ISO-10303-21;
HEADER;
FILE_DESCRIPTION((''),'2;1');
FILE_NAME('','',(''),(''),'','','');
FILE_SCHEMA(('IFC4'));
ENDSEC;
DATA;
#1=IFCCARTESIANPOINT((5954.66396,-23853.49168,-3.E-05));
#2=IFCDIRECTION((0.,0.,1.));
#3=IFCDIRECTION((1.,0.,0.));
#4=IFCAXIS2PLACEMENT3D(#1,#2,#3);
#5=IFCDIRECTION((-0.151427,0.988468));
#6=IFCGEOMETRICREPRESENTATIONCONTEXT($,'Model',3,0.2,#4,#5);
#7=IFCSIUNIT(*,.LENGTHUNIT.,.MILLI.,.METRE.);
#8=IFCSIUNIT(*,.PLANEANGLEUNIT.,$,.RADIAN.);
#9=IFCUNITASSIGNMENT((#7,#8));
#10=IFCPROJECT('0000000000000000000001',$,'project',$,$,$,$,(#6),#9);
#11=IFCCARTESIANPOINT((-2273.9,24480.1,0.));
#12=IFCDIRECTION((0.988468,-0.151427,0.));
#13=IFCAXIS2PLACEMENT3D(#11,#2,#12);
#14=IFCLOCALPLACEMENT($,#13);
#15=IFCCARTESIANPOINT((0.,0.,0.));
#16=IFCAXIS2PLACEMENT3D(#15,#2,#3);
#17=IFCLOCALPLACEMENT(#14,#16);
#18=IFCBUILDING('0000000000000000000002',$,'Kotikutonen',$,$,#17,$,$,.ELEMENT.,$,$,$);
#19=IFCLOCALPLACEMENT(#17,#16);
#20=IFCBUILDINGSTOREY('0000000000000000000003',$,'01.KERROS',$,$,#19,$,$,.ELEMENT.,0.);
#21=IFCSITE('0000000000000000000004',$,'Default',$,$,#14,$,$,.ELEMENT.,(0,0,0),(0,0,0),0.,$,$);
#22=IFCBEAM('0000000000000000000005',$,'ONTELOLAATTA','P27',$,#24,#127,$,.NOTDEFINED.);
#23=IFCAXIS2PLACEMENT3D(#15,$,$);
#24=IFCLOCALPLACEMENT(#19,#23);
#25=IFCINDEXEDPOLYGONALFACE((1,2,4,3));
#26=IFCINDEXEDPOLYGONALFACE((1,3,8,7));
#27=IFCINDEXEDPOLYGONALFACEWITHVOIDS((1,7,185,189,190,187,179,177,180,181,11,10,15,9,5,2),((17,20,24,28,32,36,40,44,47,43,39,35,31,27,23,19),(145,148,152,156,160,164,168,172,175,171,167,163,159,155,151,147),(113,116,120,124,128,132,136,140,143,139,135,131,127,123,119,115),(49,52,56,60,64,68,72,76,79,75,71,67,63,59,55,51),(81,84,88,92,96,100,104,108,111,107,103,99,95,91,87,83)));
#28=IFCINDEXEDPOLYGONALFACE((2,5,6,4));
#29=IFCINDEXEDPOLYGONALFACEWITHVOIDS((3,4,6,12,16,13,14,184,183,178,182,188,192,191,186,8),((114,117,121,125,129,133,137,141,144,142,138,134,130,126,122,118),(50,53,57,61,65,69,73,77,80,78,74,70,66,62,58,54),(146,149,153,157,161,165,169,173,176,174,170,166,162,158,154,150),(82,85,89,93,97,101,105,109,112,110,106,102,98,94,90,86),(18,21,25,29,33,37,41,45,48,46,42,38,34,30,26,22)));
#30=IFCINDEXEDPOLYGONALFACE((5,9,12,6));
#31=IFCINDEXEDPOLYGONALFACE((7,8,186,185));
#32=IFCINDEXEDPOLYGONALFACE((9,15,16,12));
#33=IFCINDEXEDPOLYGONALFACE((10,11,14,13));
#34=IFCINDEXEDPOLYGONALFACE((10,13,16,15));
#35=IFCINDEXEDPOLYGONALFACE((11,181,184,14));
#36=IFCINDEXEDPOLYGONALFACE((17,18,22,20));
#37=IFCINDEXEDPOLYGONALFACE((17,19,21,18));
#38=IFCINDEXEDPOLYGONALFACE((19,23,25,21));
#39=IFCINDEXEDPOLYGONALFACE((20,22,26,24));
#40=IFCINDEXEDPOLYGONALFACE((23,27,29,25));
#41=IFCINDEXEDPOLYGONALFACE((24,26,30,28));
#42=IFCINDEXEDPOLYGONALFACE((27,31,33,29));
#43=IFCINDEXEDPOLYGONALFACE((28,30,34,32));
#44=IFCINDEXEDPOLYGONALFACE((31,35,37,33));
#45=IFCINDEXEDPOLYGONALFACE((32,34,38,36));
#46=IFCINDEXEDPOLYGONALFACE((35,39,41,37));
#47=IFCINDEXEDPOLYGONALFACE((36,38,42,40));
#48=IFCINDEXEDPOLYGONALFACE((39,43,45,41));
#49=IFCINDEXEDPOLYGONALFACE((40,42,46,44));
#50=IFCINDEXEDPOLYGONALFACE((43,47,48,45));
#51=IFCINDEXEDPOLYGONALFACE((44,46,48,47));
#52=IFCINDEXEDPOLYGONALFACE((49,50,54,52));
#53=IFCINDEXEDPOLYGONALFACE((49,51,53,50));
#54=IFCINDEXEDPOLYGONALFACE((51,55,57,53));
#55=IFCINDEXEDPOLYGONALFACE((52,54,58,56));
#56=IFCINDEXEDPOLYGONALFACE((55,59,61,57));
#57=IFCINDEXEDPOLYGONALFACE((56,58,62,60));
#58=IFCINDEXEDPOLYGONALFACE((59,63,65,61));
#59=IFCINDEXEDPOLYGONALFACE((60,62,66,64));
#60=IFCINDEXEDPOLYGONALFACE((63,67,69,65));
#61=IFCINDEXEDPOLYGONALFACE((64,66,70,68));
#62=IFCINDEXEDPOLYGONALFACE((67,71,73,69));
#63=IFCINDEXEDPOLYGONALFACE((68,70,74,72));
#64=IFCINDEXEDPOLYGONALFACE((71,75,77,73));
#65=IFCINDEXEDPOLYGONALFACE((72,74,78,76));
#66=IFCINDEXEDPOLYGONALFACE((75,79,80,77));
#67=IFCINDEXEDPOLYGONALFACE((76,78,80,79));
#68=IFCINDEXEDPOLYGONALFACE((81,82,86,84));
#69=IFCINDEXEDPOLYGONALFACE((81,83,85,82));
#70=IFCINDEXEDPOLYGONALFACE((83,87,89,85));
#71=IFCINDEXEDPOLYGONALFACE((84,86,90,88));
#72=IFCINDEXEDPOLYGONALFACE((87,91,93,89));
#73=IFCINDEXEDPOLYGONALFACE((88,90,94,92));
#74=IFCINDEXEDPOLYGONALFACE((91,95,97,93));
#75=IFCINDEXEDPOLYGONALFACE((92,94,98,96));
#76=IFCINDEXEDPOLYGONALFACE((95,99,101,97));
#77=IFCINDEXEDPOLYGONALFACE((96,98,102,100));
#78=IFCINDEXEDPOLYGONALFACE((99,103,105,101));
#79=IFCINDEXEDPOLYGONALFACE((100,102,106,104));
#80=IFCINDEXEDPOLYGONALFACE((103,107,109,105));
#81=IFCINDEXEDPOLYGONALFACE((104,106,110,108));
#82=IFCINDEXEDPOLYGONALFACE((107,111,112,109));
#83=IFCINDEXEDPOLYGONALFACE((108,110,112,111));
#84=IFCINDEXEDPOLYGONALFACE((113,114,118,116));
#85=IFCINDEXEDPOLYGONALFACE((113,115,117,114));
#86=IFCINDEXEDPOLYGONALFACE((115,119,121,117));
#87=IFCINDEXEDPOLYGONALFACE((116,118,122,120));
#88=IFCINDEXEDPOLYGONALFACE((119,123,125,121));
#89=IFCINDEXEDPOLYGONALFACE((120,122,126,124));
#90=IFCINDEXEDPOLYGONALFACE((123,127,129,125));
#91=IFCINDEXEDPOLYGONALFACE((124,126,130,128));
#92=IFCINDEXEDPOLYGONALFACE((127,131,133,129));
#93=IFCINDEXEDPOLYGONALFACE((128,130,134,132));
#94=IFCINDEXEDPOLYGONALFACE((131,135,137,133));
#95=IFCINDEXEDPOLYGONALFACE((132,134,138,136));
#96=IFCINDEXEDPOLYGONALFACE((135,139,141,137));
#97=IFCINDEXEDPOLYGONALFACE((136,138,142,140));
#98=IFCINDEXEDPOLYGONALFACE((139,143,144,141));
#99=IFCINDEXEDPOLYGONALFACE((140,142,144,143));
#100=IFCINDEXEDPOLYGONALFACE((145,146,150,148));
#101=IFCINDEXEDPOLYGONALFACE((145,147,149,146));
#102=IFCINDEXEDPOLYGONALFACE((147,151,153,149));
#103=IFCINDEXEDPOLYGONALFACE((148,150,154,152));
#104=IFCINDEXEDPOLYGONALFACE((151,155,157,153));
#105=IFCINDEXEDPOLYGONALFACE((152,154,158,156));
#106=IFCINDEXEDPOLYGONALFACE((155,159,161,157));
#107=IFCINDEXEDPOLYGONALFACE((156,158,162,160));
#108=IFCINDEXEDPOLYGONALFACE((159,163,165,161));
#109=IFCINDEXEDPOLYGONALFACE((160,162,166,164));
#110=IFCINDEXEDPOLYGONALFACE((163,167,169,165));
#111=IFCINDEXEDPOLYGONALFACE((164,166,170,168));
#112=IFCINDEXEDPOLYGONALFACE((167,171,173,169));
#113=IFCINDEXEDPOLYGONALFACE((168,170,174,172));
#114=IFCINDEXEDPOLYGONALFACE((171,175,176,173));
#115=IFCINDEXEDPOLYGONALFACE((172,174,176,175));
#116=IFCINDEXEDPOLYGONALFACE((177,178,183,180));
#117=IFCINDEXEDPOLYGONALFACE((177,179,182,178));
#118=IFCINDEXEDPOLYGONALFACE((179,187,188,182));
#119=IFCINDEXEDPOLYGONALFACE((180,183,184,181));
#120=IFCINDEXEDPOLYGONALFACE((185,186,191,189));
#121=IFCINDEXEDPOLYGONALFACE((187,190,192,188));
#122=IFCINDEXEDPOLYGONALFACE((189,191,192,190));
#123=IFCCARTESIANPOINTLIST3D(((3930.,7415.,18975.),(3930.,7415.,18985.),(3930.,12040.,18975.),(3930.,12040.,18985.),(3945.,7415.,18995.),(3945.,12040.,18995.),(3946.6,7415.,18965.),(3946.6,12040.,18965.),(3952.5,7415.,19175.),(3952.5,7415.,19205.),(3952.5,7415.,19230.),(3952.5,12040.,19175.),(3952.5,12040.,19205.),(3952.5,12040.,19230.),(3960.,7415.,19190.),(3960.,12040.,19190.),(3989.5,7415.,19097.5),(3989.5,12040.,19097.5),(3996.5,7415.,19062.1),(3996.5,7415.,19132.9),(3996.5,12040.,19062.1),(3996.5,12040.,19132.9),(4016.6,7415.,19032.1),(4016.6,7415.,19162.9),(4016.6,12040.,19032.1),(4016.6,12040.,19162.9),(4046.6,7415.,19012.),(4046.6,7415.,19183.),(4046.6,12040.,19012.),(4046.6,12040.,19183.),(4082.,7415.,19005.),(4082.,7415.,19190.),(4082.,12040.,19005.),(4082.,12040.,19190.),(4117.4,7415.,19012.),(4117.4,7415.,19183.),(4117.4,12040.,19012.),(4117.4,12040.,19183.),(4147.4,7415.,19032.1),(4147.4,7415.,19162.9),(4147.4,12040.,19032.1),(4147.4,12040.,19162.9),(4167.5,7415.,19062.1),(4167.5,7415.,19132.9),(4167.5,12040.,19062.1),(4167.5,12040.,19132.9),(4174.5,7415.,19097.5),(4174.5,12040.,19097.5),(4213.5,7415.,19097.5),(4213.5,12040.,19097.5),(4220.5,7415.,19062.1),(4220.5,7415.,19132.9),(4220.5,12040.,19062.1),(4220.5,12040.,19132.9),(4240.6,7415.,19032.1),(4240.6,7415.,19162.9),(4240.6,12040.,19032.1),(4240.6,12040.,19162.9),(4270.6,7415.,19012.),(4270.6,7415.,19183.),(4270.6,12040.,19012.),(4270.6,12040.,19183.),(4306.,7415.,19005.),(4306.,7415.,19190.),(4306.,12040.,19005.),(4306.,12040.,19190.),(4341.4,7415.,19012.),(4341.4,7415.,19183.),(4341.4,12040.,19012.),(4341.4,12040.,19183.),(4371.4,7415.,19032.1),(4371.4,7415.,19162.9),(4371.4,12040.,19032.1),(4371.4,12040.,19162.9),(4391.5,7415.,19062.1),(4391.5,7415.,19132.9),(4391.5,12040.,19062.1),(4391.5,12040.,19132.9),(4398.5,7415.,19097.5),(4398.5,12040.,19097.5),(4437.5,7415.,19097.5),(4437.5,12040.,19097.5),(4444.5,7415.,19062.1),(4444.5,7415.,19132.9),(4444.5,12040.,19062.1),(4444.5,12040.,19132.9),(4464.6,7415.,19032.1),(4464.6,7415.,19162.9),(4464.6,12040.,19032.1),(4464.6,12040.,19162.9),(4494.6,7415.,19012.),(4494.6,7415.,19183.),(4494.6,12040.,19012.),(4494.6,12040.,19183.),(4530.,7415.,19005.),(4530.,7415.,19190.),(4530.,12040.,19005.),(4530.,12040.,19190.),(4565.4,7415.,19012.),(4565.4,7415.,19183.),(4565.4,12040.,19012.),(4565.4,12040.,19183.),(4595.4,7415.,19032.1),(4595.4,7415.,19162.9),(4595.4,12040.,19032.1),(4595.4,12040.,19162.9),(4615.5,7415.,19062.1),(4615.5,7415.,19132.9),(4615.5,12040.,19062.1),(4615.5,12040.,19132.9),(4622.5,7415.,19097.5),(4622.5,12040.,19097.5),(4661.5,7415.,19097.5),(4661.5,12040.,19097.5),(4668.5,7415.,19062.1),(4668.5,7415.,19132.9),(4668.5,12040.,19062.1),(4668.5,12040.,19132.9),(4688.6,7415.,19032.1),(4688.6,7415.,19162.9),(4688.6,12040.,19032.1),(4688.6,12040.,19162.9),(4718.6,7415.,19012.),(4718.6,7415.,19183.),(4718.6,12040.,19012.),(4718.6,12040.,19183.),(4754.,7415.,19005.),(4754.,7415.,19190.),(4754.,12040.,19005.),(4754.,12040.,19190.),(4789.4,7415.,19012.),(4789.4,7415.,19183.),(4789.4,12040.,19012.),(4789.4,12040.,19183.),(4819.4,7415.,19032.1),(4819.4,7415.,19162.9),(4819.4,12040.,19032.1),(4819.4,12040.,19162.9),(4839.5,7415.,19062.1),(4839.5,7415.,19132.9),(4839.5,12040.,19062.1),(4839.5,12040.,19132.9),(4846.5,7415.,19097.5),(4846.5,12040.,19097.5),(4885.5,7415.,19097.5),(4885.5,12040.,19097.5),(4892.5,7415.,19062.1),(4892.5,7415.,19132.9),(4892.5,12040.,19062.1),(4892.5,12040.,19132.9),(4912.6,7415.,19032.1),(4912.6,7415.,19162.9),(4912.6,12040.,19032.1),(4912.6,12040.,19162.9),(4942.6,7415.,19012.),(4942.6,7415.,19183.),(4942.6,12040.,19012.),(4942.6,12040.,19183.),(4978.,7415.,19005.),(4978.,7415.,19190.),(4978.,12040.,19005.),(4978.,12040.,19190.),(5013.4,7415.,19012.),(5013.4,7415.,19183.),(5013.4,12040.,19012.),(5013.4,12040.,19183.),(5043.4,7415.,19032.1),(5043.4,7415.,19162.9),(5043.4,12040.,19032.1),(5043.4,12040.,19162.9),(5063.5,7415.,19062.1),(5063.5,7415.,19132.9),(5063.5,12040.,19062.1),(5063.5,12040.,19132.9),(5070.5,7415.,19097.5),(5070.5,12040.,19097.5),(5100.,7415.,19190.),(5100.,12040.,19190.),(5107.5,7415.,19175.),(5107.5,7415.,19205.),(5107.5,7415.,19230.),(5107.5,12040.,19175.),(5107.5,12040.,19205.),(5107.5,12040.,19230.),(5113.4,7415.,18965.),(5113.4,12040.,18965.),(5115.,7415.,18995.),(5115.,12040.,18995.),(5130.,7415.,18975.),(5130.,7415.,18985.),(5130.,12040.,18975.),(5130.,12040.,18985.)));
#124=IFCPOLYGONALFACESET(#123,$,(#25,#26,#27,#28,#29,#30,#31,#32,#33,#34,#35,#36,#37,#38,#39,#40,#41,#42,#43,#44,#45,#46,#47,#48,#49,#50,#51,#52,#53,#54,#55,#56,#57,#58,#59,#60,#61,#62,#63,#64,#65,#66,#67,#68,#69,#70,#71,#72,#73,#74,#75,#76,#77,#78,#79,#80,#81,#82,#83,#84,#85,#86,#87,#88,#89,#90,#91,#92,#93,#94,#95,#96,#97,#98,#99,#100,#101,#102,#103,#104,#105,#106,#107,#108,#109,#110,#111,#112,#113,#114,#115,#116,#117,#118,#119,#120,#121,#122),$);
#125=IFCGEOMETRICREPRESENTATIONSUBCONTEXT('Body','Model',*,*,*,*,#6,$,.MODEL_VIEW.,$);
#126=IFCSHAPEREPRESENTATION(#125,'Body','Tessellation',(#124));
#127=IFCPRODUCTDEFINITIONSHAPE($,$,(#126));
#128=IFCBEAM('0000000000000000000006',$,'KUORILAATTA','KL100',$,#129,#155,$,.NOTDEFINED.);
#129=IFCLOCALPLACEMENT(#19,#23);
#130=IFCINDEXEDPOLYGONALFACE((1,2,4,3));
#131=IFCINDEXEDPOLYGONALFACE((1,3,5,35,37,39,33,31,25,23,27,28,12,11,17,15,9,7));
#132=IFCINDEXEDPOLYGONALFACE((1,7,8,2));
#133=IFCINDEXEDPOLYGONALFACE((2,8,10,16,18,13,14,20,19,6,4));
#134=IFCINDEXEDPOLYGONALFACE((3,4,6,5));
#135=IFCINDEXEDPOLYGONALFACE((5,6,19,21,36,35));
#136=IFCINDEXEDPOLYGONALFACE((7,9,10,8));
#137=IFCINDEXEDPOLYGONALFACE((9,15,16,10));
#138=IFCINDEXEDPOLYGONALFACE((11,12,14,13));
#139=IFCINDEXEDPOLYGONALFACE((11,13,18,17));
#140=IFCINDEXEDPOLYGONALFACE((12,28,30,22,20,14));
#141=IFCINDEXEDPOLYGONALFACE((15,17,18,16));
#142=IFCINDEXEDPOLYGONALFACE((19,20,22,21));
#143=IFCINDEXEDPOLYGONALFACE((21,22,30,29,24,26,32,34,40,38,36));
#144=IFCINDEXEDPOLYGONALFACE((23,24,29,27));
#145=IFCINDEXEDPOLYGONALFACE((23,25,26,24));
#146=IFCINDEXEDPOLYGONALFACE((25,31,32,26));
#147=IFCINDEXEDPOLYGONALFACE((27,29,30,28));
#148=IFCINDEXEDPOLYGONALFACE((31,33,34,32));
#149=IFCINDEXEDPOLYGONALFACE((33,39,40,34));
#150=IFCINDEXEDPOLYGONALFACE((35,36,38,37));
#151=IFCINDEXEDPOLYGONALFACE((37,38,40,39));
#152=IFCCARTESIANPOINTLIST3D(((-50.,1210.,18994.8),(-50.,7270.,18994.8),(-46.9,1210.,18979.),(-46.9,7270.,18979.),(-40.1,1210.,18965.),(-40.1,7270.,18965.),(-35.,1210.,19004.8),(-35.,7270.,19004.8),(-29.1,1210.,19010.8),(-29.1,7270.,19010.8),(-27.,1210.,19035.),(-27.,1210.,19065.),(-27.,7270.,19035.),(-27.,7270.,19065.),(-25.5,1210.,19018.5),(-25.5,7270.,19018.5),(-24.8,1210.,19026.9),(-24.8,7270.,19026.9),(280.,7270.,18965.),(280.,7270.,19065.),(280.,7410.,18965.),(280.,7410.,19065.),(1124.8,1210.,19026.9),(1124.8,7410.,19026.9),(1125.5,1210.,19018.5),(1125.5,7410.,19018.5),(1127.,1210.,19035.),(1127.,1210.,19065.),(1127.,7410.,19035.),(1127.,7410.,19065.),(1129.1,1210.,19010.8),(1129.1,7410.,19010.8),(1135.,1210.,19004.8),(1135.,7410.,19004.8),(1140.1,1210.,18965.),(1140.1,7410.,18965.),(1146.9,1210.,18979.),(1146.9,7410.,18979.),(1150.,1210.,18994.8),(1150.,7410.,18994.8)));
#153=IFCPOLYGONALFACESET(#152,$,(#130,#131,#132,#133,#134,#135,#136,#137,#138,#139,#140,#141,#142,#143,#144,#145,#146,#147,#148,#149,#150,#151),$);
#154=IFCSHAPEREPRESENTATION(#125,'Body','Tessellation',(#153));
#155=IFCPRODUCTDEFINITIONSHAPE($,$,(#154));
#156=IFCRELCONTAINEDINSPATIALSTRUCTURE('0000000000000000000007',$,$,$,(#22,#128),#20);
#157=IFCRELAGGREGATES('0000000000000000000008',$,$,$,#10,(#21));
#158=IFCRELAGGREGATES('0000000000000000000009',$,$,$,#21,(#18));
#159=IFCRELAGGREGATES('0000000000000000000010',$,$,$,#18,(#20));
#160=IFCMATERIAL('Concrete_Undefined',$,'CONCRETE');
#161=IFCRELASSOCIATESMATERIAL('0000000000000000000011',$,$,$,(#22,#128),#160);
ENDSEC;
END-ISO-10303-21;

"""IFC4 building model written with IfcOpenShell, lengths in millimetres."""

from ifc_helpers import new_model, si_unit, direction, frame, origin_with_axes, place, context, subcontext, project, spatial, line, indexed_curve, outline, extrude, material, element, save


model = new_model("IFC4")

# Units and contexts
model_context = context("Model", 3, precision=0.2, world=frame((5954.66396, -23853.49168, -3e-05), z_axis=(0.0, 0.0, 1.0), x_axis=(1.0, 0.0, 0.0)), true_north=direction((-0.151427, 0.988468)))
body_context = subcontext(model_context, "Body", "Model", "MODEL_VIEW")
ifc_project = project(units=[si_unit("LENGTHUNIT", "METRE", prefix="MILLI"), si_unit("PLANEANGLEUNIT", "RADIAN")], contexts=[model_context])

# Site, building, storey
site_placement = place(None, frame((-2273.9, 24480.1, 0.0), z_axis=(0.0, 0.0, 1.0), x_axis=(0.988468, -0.151427, 0.0)))
site = spatial("IfcSite", under=ifc_project, at=site_placement, Name="Default", CompositionType="ELEMENT", RefLatitude=(0, 0, 0), RefLongitude=(0, 0, 0), RefElevation=0.0)
building_placement = place(site_placement, origin_with_axes())
building = spatial("IfcBuilding", under=site, at=building_placement, Name="Kotikutonen", CompositionType="ELEMENT")
storey_placement = place(building_placement, origin_with_axes())
storey = spatial("IfcBuildingStorey", under=building, at=storey_placement, Name="01.KERROS", CompositionType="ELEMENT", Elevation=0.0)

# Shared definitions
ifc_material_1 = material(Name="Concrete_Undefined", Category="CONCRETE")

# Beam
beam_1_placement = place(storey_placement, frame((4530.0, 12040.0, 19097.5), z_axis=(-1.0, 0.0, 0.0), x_axis=(0.0, -1.0, 0.0)))
element("IfcBeam", 1, at=beam_1_placement, inside=storey, material=ifc_material_1, Name="ONTELOLAATTA", Description="P27", PredefinedType="NOTDEFINED", context=body_context, shape_type="SolidModel", body=[
    extrude(outline(indexed_curve([(-600.0, -122.5), (-583.4, -132.5), (583.4, -132.5), (600.0, -122.5), (600.0, -112.5), (585.0, -102.5), (577.5, 77.5), (570.0, 92.5), (577.5, 107.5), (577.5, 132.5), (-577.5, 132.5), (-577.5, 107.5), (-570.0, 92.5), (-577.5, 77.5), (-585.0, -102.5), (-600.0, -112.5)], segments=[line(1, 2, 3, 4, 5, 6, 7, 8, 9, 10, 11, 12, 13, 14, 15, 16, 1)]), holes=[indexed_curve([(-448.0, -92.5), (-483.4, -85.5), (-513.4, -65.4), (-533.5, -35.4), (-540.5, 0.0), (-533.5, 35.4), (-513.4, 65.4), (-483.4, 85.5), (-448.0, 92.5), (-412.6, 85.5), (-382.6, 65.4), (-362.5, 35.4), (-355.5, 0.0), (-362.5, -35.4), (-382.6, -65.4), (-412.6, -85.5)], segments=[line(1, 2, 3, 4, 5, 6, 7, 8, 9, 10, 11, 12, 13, 14, 15, 16, 1)]), indexed_curve([(-224.0, -92.5), (-259.4, -85.5), (-289.4, -65.4), (-309.5, -35.4), (-316.5, 0.0), (-309.5, 35.4), (-289.4, 65.4), (-259.4, 85.5), (-224.0, 92.5), (-188.6, 85.5), (-158.6, 65.4), (-138.5, 35.4), (-131.5, 0.0), (-138.5, -35.4), (-158.6, -65.4), (-188.6, -85.5)], segments=[line(1, 2, 3, 4, 5, 6, 7, 8, 9, 10, 11, 12, 13, 14, 15, 16, 1)]), indexed_curve([(0.0, -92.5), (-35.4, -85.5), (-65.4, -65.4), (-85.5, -35.4), (-92.5, 0.0), (-85.5, 35.4), (-65.4, 65.4), (-35.4, 85.5), (0.0, 92.5), (35.4, 85.5), (65.4, 65.4), (85.5, 35.4), (92.5, 0.0), (85.5, -35.4), (65.4, -65.4), (35.4, -85.5)], segments=[line(1, 2, 3, 4, 5, 6, 7, 8, 9, 10, 11, 12, 13, 14, 15, 16, 1)]), indexed_curve([(224.0, -92.5), (188.6, -85.5), (158.6, -65.4), (138.5, -35.4), (131.5, 0.0), (138.5, 35.4), (158.6, 65.4), (188.6, 85.5), (224.0, 92.5), (259.4, 85.5), (289.4, 65.4), (309.5, 35.4), (316.5, 0.0), (309.5, -35.4), (289.4, -65.4), (259.4, -85.5)], segments=[line(1, 2, 3, 4, 5, 6, 7, 8, 9, 10, 11, 12, 13, 14, 15, 16, 1)]), indexed_curve([(448.0, -92.5), (412.6, -85.5), (382.6, -65.4), (362.5, -35.4), (355.5, 0.0), (362.5, 35.4), (382.6, 65.4), (412.6, 85.5), (448.0, 92.5), (483.4, 85.5), (513.4, 65.4), (533.5, 35.4), (540.5, 0.0), (533.5, -35.4), (513.4, -65.4), (483.4, -85.5)], segments=[line(1, 2, 3, 4, 5, 6, 7, 8, 9, 10, 11, 12, 13, 14, 15, 16, 1)])]), frame((0.0, 0.0, 0.0), z_axis=(-1.0, 0.0, 0.0), x_axis=(0.0, 0.0, 1.0)), (0.0, 0.0, -1.0), 4625.0),
])

# Beam, voiding feature
beam_2_placement = place(storey_placement, frame((550.0, 7410.0, 19015.0), z_axis=(-1.0, 0.0, 0.0), x_axis=(0.0, -1.0, 0.0)))
beam_2 = element("IfcBeam", 2, at=beam_2_placement, inside=storey, material=ifc_material_1, Name="KUORILAATTA", Description="KL100", PredefinedType="NOTDEFINED", context=body_context, shape_type="SolidModel", body=[
    extrude(outline(indexed_curve([(-596.9, -36.0), (-590.1, -50.0), (590.1, -50.0), (596.9, -36.0), (600.0, -20.2), (585.0, -10.2), (579.1, -4.2), (575.5, 3.5), (574.8, 11.9), (577.0, 20.0), (577.0, 50.0), (-577.0, 50.0), (-577.0, 20.0), (-574.8, 11.9), (-575.5, 3.5), (-579.1, -4.2), (-585.0, -10.2), (-600.0, -20.2)], segments=[line(1, 2, 3, 4, 5, 6, 7, 8, 9, 10, 11, 12, 13, 14, 15, 16, 17, 18, 1)])), frame((0.0, 0.0, 0.0), z_axis=(-1.0, 0.0, 0.0), x_axis=(0.0, 0.0, 1.0)), (0.0, 0.0, -1.0), 6200.0),
])
voiding_feature_1_placement = place(beam_2_placement, frame((140.0, 0.0, 270.0), z_axis=(0.0, 1.0, 0.0), x_axis=(-1.0, 0.0, 0.0)))
element("IfcVoidingFeature", 3, at=voiding_feature_1_placement, cuts=beam_2, Name="Opening", PredefinedType="HOLE", context=body_context, shape_type="SolidModel", body=[
    extrude(outline(indexed_curve([(0.0, 0.0), (390.0, 0.0), (390.0, 580.0), (0.0, 580.0)], segments=[line(1, 2, 3, 4, 1)])), frame((0.0, 0.0, 125.0), z_axis=(0.0, 0.0, 1.0), x_axis=(1.0, 0.0, 0.0)), (0.0, 0.0, -1.0), 250.0),
])

save(model, "model.ifc")
